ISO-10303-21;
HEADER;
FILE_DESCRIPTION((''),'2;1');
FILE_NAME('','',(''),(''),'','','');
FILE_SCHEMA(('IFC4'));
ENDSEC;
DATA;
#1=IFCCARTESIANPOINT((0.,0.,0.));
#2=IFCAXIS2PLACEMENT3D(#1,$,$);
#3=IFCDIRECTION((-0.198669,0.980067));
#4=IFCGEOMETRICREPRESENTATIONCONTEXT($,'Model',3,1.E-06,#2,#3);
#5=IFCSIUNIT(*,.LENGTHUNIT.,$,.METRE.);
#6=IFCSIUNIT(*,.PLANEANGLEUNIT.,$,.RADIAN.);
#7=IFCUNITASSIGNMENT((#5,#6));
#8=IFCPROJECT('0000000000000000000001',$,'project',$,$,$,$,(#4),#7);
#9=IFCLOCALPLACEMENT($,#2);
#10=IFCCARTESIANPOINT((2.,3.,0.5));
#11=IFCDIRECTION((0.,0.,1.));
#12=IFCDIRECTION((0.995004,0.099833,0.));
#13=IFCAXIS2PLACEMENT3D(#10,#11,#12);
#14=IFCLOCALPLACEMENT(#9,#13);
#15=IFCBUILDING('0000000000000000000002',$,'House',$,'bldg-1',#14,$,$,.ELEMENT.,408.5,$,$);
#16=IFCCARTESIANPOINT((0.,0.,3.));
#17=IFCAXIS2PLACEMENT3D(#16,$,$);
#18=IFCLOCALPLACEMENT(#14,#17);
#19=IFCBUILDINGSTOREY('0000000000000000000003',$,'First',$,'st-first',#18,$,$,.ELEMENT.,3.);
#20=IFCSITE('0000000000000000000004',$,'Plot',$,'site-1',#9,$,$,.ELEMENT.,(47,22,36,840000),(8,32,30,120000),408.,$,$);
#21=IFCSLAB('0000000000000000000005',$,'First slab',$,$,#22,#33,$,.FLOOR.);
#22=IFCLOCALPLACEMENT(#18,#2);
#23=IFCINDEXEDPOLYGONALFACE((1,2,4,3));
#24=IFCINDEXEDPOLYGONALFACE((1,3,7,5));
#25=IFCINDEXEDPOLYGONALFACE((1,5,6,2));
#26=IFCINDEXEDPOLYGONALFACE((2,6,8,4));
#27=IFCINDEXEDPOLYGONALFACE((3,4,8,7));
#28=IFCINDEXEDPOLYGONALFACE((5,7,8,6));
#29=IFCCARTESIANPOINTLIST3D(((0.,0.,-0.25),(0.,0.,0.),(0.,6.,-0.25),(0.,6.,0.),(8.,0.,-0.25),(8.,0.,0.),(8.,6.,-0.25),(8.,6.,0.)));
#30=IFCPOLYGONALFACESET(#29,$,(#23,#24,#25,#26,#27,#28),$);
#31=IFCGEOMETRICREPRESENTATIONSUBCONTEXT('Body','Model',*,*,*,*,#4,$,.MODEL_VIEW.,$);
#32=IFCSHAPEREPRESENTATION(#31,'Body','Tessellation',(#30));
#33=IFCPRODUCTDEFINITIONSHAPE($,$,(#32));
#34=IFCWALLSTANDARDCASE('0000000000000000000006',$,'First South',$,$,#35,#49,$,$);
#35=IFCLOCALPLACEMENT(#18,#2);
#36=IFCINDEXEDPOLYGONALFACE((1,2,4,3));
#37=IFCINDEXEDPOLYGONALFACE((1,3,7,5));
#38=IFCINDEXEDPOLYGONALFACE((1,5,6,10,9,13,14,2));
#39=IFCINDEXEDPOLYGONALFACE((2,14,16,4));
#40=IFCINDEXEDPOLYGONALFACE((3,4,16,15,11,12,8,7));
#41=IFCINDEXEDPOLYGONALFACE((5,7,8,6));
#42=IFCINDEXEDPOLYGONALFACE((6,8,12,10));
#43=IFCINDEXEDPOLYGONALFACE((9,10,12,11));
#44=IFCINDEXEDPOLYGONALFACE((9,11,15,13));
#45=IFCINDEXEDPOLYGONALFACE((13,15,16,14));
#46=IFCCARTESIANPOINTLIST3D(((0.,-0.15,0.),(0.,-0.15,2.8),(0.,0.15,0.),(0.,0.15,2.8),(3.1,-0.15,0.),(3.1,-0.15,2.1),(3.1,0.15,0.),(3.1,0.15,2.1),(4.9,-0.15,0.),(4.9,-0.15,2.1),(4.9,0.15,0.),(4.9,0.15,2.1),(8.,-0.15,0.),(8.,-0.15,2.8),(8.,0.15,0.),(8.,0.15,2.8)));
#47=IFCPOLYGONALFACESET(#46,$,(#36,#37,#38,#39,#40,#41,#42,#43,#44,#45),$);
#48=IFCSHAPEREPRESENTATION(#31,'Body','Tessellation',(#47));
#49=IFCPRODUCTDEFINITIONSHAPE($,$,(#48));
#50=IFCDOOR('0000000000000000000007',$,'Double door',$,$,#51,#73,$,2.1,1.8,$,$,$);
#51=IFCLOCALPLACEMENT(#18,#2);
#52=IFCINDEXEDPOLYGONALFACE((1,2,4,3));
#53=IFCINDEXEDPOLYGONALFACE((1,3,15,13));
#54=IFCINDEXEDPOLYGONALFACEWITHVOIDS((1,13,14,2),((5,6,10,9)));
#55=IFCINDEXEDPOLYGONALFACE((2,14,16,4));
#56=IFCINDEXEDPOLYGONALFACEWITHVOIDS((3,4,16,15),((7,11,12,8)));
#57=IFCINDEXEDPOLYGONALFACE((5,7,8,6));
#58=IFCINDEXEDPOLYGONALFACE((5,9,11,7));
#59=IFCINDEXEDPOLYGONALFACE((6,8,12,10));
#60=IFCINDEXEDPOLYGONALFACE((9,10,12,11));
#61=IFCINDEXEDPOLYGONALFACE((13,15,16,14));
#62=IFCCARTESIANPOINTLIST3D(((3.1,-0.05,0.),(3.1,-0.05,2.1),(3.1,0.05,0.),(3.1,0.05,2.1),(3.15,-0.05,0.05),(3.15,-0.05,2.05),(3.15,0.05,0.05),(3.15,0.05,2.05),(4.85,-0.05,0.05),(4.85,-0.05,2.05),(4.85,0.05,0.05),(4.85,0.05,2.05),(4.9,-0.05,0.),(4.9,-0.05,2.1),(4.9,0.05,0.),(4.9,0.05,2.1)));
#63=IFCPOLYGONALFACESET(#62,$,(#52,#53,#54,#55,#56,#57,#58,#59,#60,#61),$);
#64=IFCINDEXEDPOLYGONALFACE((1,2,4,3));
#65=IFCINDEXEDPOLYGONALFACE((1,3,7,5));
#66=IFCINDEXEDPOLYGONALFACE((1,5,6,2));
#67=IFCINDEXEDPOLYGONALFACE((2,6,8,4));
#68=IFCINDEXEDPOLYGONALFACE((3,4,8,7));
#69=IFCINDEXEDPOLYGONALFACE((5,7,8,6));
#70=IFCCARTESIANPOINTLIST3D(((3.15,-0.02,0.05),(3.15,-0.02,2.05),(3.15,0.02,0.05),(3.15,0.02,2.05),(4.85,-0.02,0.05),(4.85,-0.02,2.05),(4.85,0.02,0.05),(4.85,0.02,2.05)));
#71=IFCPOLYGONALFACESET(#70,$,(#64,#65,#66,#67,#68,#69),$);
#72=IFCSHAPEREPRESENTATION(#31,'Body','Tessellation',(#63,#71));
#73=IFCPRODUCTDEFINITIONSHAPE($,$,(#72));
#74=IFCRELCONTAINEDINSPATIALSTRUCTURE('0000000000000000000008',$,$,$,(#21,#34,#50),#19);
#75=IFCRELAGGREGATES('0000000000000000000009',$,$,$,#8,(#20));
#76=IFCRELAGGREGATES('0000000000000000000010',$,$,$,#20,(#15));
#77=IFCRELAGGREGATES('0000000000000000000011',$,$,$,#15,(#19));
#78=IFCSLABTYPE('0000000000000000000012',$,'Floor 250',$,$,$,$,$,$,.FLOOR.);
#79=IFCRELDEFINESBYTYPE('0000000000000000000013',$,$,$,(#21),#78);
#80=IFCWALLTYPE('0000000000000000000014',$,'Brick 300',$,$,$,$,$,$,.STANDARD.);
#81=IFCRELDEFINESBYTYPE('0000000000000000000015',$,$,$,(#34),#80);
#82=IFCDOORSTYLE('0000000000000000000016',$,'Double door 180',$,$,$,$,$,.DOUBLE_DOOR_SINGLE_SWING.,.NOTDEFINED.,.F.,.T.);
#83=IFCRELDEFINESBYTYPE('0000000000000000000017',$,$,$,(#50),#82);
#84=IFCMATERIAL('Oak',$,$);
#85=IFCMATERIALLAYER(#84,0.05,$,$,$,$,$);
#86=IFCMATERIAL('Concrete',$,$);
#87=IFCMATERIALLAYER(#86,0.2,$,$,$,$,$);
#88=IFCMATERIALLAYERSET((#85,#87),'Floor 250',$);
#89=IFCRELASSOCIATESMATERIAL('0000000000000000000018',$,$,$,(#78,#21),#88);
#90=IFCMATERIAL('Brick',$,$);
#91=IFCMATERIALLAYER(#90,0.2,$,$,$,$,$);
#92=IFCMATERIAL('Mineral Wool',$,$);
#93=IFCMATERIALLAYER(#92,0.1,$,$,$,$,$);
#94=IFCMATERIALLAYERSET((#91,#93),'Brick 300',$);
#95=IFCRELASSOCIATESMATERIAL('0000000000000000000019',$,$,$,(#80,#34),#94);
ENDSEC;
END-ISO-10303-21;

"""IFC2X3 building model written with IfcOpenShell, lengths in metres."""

from ifc_helpers import new_model, si_unit, direction, frame, frame_2d, origin, origin_with_axes, origin_2d, place, context, subcontext, project, spatial, polyline, rectangle, outline, extrude, material, layer, layer_set, layer_usage, type_object, element, fill, save


model = new_model("IFC2X3")

# Units and contexts
model_context = context("Model", 3, precision=1e-06, world=origin(), true_north=direction((-0.198669, 0.980067)))
body_context = subcontext(model_context, "Body", "Model", "MODEL_VIEW")
ifc_project = project(units=[si_unit("LENGTHUNIT", "METRE"), si_unit("PLANEANGLEUNIT", "RADIAN")], contexts=[model_context])

# Site, building, storey
site_placement = place(None, origin())
site = spatial("IfcSite", under=ifc_project, at=site_placement, Name="Plot", ObjectType="site-1", CompositionType="ELEMENT", RefLatitude=(47, 22, 36, 840000), RefLongitude=(8, 32, 30, 120000), RefElevation=408.0)
building_placement = place(site_placement, frame((2.0, 3.0, 0.5), z_axis=(0.0, 0.0, 1.0), x_axis=(0.995004, 0.099833, 0.0)))
building = spatial("IfcBuilding", under=site, at=building_placement, Name="House", ObjectType="bldg-1", CompositionType="ELEMENT", ElevationOfRefHeight=408.5)
storey_placement = place(building_placement, frame((0.0, 0.0, 3.0)))
storey = spatial("IfcBuildingStorey", under=building, at=storey_placement, Name="First", ObjectType="st-first", CompositionType="ELEMENT", Elevation=3.0)

# Slab
ifc_material_1 = material(Name="Oak")
ifc_layer_1 = layer(ifc_material_1, 0.05)
ifc_material_2 = material(Name="Concrete")
ifc_layer_2 = layer(ifc_material_2, 0.2)
ifc_layer_set_1 = layer_set([ifc_layer_1, ifc_layer_2], Name="Floor 250")
ifc_layer_usage_1 = layer_usage(ifc_layer_set_1, "AXIS3", "NEGATIVE", 0.25)
slab_type = type_object("IfcSlabType", Name="Floor 250", PredefinedType="FLOOR", material=ifc_layer_set_1)
slab_placement = place(storey_placement, frame((0.0, 0.0, -0.25)))
element("IfcSlab", 1, at=slab_placement, inside=storey, type_object=slab_type, material=ifc_layer_usage_1, Name="First slab", PredefinedType="FLOOR", context=body_context, shape_type="SweptSolid", body=[
    extrude(outline(polyline([(0.0, 0.0), (8.0, 0.0), (8.0, 6.0), (0.0, 6.0), (0.0, 0.0)])), origin(), (0.0, 0.0, 1.0), 0.25),
])

# Wall, opening, door
ifc_material_3 = material(Name="Brick")
ifc_layer_3 = layer(ifc_material_3, 0.2)
ifc_material_4 = material(Name="Mineral Wool")
ifc_layer_4 = layer(ifc_material_4, 0.1)
ifc_layer_set_2 = layer_set([ifc_layer_3, ifc_layer_4], Name="Brick 300")
ifc_layer_usage_2 = layer_usage(ifc_layer_set_2, "AXIS2", "NEGATIVE", 0.15)
wall_type = type_object("IfcWallType", Name="Brick 300", PredefinedType="STANDARD", material=ifc_layer_set_2)
wall_placement = place(storey_placement, origin_with_axes())
wall = element("IfcWallStandardCase", 2, at=wall_placement, inside=storey, type_object=wall_type, material=ifc_layer_usage_2, Name="First South", context=body_context, shape_type="SweptSolid", body=[
    extrude(rectangle(XDim=8.0, YDim=0.3, at=frame_2d((4.0, 0.0))), origin(), (0.0, 0.0, 1.0), 2.8),
])
opening_placement = place(wall_placement, frame((4.0, 0.0, 0.0)))
opening = element("IfcOpeningElement", 3, at=opening_placement, cuts=wall, context=body_context, shape_type="SweptSolid", body=[
    extrude(rectangle(XDim=1.8, YDim=0.3, at=origin_2d()), origin(), (0.0, 0.0, 1.0), 2.1),
])
door_style = type_object("IfcDoorStyle", Name="Double door 180", ConstructionType="NOTDEFINED", OperationType="DOUBLE_DOOR_SINGLE_SWING", ParameterTakesPrecedence=False, Sizeable=True)
door_placement = place(opening_placement, frame((0.0, 0.0, 0.0), z_axis=(0.0, -1.0, 0.0), x_axis=(1.0, 0.0, 0.0)))
door = element("IfcDoor", 4, at=door_placement, inside=storey, type_object=door_style, Name="Double door", OverallHeight=2.1, OverallWidth=1.8, context=body_context, shape_type="SweptSolid", body=[
    extrude(outline(polyline([(-0.9, 0.0), (0.9, 0.0), (0.9, 2.1), (-0.9, 2.1), (-0.9, 0.0)]), holes=[polyline([(-0.85, 0.05), (0.85, 0.05), (0.85, 2.05), (-0.85, 2.05), (-0.85, 0.05)])]), frame((0.0, 0.0, -0.05)), (0.0, 0.0, 1.0), 0.1),
    extrude(rectangle(XDim=1.7, YDim=2.0, at=frame_2d((0.0, 1.05))), frame((0.0, 0.0, -0.02)), (0.0, 0.0, 1.0), 0.04),
])
fill(opening, door)

save(model, "model.ifc")
